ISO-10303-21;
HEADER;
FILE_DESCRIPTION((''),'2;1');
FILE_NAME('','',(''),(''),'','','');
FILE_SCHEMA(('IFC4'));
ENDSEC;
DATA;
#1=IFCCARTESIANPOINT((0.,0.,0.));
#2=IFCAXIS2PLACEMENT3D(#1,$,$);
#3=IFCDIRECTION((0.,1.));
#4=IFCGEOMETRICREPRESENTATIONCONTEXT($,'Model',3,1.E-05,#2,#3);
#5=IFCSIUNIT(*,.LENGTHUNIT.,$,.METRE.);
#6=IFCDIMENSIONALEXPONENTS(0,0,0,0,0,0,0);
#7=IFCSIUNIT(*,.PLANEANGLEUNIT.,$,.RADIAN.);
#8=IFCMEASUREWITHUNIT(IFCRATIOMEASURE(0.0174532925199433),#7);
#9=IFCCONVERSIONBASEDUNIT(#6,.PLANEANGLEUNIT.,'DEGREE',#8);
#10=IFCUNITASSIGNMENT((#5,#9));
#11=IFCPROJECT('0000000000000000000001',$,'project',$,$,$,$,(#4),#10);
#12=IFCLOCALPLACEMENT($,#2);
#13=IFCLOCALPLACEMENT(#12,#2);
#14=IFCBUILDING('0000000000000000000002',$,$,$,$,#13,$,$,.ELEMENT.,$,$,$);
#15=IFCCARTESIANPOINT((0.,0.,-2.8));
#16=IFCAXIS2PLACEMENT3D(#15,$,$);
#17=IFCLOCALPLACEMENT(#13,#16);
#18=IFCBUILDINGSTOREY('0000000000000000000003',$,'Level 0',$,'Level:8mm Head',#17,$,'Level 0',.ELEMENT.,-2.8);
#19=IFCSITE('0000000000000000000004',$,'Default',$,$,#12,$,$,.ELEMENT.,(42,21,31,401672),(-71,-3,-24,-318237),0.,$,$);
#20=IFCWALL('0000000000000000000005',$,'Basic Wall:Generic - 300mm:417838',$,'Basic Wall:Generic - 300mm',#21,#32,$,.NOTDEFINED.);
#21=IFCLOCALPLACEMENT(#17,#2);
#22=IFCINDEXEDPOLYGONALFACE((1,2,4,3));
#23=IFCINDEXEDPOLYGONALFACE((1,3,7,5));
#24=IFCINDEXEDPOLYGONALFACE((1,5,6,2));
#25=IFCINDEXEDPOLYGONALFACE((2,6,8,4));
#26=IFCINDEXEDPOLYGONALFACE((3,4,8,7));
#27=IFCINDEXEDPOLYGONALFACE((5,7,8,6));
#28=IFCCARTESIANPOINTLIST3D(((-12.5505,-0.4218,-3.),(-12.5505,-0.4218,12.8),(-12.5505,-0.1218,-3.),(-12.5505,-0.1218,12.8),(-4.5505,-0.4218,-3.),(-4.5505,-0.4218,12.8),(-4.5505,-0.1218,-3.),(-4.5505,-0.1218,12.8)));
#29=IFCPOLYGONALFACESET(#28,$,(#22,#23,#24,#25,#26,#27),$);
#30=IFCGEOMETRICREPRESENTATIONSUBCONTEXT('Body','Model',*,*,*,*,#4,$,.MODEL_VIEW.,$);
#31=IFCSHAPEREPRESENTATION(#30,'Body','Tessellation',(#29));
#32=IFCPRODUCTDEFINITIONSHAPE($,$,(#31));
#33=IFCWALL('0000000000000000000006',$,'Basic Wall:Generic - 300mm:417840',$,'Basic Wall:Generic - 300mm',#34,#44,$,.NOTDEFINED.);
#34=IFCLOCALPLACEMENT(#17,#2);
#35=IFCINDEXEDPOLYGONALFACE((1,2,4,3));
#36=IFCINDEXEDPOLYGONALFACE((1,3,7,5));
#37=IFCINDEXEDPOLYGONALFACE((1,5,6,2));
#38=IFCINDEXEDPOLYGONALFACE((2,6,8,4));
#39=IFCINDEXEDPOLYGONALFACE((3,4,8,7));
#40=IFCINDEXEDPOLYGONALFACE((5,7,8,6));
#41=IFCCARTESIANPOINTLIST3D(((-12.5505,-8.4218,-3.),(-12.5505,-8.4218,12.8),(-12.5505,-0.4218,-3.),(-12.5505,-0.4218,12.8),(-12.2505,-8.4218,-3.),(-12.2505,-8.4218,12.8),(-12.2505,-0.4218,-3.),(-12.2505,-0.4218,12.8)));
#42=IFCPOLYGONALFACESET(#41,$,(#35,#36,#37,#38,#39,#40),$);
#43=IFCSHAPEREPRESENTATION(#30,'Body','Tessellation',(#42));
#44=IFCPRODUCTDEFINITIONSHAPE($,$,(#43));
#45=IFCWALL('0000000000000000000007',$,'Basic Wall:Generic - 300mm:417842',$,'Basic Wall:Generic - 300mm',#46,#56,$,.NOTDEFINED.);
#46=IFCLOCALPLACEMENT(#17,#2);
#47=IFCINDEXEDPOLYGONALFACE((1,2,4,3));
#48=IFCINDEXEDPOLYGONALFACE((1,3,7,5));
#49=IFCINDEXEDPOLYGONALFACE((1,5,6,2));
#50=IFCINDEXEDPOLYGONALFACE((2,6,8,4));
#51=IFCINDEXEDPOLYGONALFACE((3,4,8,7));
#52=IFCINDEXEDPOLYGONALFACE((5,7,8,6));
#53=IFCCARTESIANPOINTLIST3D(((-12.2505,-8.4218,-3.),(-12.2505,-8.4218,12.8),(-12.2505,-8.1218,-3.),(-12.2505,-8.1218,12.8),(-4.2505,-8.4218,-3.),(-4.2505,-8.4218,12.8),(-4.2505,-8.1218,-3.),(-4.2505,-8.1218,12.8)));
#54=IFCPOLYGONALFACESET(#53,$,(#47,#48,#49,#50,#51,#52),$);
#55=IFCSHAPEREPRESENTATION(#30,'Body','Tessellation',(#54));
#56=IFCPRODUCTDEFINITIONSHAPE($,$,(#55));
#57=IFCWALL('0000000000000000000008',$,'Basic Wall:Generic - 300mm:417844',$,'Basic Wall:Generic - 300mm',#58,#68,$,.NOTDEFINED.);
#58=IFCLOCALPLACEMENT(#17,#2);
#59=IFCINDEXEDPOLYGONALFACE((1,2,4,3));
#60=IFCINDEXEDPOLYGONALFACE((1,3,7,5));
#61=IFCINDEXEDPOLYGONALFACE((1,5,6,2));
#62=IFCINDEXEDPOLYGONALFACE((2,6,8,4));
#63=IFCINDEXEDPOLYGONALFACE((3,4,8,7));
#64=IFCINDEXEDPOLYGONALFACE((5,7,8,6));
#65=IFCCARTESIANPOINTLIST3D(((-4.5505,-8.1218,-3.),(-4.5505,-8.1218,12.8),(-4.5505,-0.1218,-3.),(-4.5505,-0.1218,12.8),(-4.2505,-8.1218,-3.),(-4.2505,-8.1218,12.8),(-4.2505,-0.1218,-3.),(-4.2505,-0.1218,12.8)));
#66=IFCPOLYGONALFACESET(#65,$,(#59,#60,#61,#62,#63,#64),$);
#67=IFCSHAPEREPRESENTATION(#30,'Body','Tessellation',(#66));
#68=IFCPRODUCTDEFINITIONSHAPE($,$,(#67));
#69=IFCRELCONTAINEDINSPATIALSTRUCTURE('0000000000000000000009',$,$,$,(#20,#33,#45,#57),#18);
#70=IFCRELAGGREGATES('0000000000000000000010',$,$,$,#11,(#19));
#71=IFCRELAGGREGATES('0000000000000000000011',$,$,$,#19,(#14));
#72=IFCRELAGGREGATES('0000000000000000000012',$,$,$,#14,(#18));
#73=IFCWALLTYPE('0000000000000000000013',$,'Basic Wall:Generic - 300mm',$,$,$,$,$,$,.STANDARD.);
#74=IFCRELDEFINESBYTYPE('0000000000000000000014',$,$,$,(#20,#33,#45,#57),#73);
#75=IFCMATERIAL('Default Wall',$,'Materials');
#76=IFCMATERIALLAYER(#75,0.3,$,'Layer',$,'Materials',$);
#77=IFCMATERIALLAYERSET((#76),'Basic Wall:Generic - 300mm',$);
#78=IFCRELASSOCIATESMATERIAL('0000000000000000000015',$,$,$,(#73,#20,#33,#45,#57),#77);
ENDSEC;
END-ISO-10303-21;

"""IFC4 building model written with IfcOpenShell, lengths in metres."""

from ifc_helpers import new_model, entity, si_unit, converted_unit, direction, frame, frame_2d, origin, place, context, subcontext, project, spatial, rectangle, extrude, material, layer, layer_set, layer_usage, type_object, element, save


model = new_model("IFC4")

# Units and contexts
model_context = context("Model", 3, precision=1e-05, world=origin(), true_north=direction((0.0, 1.0)))
body_context = subcontext(model_context, "Body", "Model", "MODEL_VIEW")
ifc_project = project(units=[si_unit("LENGTHUNIT", "METRE"), converted_unit("PLANEANGLEUNIT", "DEGREE", entity("IfcRatioMeasure", 0.0174532925199433), si_unit("PLANEANGLEUNIT", "RADIAN"), dimensions=[0, 0, 0, 0, 0, 0, 0])], contexts=[model_context])

# Site, building, storey
site_placement = place(None, origin())
site = spatial("IfcSite", under=ifc_project, at=site_placement, Name="Default", CompositionType="ELEMENT", RefLatitude=(42, 21, 31, 401672), RefLongitude=(-71, -3, -24, -318237), RefElevation=0.0)
building_placement = place(site_placement, origin())
building = spatial("IfcBuilding", under=site, at=building_placement, CompositionType="ELEMENT")
storey_placement = place(building_placement, frame((0.0, 0.0, -2.8)))
storey = spatial("IfcBuildingStorey", under=building, at=storey_placement, Name="Level 0", ObjectType="Level:8mm Head", LongName="Level 0", CompositionType="ELEMENT", Elevation=-2.8)

# Walls
ifc_material_1 = material(Name="Default Wall", Category="Materials")
ifc_layer = layer(ifc_material_1, 0.3, Name="Layer", Category="Materials")
ifc_layer_set = layer_set([ifc_layer], Name="Basic Wall:Generic - 300mm")
ifc_layer_usage = layer_usage(ifc_layer_set, "AXIS2", "NEGATIVE", 0.15)
wall_type = type_object("IfcWallType", Name="Basic Wall:Generic - 300mm", PredefinedType="STANDARD", material=ifc_layer_set)
wall_1_placement = place(storey_placement, frame((-12.5505, -0.2718, -3.0)))
element("IfcWall", 1, at=wall_1_placement, inside=storey, type_object=wall_type, material=ifc_layer_usage, Name="Basic Wall:Generic - 300mm:417838", ObjectType="Basic Wall:Generic - 300mm", PredefinedType="NOTDEFINED", context=body_context, shape_type="SweptSolid", body=[
    extrude(rectangle(XDim=8.0, YDim=0.3, at=frame_2d((4.0, 0.0), x_axis=(-1.0, 0.0))), origin(), (0.0, 0.0, 1.0), 15.8),
])
wall_2_placement = place(storey_placement, frame((-12.4005, -8.4218, -3.0), z_axis=(0.0, 0.0, 1.0), x_axis=(0.0, 1.0, 0.0)))
element("IfcWall", 2, at=wall_2_placement, inside=storey, type_object=wall_type, material=ifc_layer_usage, Name="Basic Wall:Generic - 300mm:417840", ObjectType="Basic Wall:Generic - 300mm", PredefinedType="NOTDEFINED", context=body_context, shape_type="SweptSolid", body=[
    extrude(rectangle(XDim=8.0, YDim=0.3, at=frame_2d((4.0, 0.0), x_axis=(-1.0, 0.0))), origin(), (0.0, 0.0, 1.0), 15.8),
])
wall_3_placement = place(storey_placement, frame((-4.2505, -8.2718, -3.0), z_axis=(0.0, 0.0, 1.0), x_axis=(-1.0, 0.0, 0.0)))
element("IfcWall", 3, at=wall_3_placement, inside=storey, type_object=wall_type, material=ifc_layer_usage, Name="Basic Wall:Generic - 300mm:417842", ObjectType="Basic Wall:Generic - 300mm", PredefinedType="NOTDEFINED", context=body_context, shape_type="SweptSolid", body=[
    extrude(rectangle(XDim=8.0, YDim=0.3, at=frame_2d((4.0, 0.0), x_axis=(-1.0, 0.0))), origin(), (0.0, 0.0, 1.0), 15.8),
])
wall_4_placement = place(storey_placement, frame((-4.4005, -0.1218, -3.0), z_axis=(0.0, 0.0, 1.0), x_axis=(0.0, -1.0, 0.0)))
element("IfcWall", 4, at=wall_4_placement, inside=storey, type_object=wall_type, material=ifc_layer_usage, Name="Basic Wall:Generic - 300mm:417844", ObjectType="Basic Wall:Generic - 300mm", PredefinedType="NOTDEFINED", context=body_context, shape_type="SweptSolid", body=[
    extrude(rectangle(XDim=8.0, YDim=0.3, at=frame_2d((4.0, 0.0), x_axis=(-1.0, 0.0))), origin(), (0.0, 0.0, 1.0), 15.8),
])

save(model, "model.ifc")
